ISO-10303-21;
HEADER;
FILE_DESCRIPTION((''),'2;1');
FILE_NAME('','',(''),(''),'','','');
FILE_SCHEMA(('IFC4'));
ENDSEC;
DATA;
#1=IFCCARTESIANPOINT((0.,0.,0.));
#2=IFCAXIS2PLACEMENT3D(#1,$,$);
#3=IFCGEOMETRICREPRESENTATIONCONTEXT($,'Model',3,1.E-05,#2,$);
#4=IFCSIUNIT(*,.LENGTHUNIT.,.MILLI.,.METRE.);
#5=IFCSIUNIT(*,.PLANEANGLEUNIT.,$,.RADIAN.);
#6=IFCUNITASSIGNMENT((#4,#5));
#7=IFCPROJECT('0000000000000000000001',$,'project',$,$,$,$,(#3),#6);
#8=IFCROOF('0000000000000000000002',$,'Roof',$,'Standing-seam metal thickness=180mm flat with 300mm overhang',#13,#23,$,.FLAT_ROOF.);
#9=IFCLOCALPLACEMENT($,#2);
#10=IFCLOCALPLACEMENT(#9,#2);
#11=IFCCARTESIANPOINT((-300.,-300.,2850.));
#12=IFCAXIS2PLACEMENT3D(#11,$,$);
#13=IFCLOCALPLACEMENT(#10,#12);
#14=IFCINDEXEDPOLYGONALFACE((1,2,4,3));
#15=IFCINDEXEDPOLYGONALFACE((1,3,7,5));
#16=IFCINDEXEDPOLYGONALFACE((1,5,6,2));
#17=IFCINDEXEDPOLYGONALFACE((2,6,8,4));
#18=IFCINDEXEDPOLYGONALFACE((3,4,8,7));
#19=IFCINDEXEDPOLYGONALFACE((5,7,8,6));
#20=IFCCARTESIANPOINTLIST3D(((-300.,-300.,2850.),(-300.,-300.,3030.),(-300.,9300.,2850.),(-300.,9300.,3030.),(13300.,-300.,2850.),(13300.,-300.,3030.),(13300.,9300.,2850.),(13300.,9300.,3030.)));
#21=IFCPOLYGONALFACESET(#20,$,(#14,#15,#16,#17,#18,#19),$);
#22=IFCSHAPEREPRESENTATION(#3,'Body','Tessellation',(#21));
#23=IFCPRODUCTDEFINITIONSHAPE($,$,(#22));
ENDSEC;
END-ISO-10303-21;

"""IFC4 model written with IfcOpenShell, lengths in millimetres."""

from ifc_helpers import new_model, si_unit, frame, frame_2d, origin, place, context, project, rectangle, extrude, element, save


model = new_model("IFC4")

# Units and contexts
model_context = context("Model", 3, precision=1e-05, world=origin())
ifc_project = project(units=[si_unit("LENGTHUNIT", "METRE", prefix="MILLI"), si_unit("PLANEANGLEUNIT", "RADIAN")], contexts=[model_context])

# Roof
placement_1 = place(None, origin())
placement_2 = place(placement_1, origin())
roof_placement = place(placement_2, frame((-300.0, -300.0, 2850.0)))
element("IfcRoof", 1, at=roof_placement, Name="Roof", ObjectType="Standing-seam metal thickness=180mm flat with 300mm overhang", PredefinedType="FLAT_ROOF", context=model_context, shape_type="SweptSolid", body=[
    extrude(rectangle(XDim=13600.0, YDim=9600.0, at=frame_2d((6800.0, 4800.0))), frame((-300.0, -300.0, 2850.0)), (0.0, 0.0, 1.0), 180.0),
])

save(model, "model.ifc")
